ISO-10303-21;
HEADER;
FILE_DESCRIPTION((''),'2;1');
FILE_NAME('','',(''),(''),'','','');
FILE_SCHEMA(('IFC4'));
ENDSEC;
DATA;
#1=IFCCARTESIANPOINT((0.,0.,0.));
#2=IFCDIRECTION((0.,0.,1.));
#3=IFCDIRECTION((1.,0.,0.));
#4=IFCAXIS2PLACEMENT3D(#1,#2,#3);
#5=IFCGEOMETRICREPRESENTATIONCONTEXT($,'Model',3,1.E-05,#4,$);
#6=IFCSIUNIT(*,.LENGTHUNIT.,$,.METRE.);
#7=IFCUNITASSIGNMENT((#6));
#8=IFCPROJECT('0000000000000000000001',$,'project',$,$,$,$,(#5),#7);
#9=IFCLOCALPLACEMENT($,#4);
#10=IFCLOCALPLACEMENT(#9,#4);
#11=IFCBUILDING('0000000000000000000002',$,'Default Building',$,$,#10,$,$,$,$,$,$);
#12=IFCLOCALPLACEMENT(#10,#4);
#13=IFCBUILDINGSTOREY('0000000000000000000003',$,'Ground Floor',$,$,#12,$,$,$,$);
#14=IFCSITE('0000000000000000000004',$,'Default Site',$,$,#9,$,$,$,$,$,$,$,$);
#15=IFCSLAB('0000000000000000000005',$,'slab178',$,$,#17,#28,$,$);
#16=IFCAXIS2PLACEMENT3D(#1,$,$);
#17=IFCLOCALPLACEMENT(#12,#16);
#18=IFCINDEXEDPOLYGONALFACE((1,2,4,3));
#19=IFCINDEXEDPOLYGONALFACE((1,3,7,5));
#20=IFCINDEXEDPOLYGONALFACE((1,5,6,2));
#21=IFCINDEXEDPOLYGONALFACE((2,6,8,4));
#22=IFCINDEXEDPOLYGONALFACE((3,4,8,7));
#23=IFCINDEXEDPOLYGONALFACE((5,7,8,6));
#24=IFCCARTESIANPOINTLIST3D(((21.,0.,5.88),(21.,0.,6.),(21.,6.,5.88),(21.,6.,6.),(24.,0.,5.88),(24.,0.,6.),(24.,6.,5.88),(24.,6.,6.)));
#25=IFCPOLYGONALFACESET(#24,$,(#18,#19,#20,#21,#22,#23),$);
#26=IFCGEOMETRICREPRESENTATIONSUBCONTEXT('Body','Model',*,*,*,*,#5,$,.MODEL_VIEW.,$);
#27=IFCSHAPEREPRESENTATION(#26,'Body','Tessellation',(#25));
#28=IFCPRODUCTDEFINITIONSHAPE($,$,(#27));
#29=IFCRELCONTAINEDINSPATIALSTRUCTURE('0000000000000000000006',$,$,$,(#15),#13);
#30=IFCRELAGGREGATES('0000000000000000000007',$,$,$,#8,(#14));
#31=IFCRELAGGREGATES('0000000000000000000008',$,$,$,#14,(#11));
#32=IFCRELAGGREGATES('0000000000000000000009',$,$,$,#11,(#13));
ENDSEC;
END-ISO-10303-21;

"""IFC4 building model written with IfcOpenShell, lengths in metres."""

from ifc_helpers import new_model, si_unit, frame, origin_with_axes, place, context, subcontext, project, spatial, indexed_curve, outline, extrude, element, save


model = new_model("IFC4")

# Units and contexts
model_context = context("Model", 3, precision=1e-05, world=origin_with_axes())
body_context = subcontext(model_context, "Body", "Model", "MODEL_VIEW")
ifc_project = project(units=[si_unit("LENGTHUNIT", "METRE")], contexts=[model_context])

# Site, building, storey
site_placement = place(None, origin_with_axes())
site = spatial("IfcSite", under=ifc_project, at=site_placement, Name="Default Site")
building_placement = place(site_placement, origin_with_axes())
building = spatial("IfcBuilding", under=site, at=building_placement, Name="Default Building")
storey_placement = place(building_placement, origin_with_axes())
storey = spatial("IfcBuildingStorey", under=building, at=storey_placement, Name="Ground Floor")

# Slab
for number, where, z_axis, x_axis, name in (
    (1, (21.0, 0.0, 5.88), (0.0, 0.0, 1.0), (1.0, 0.0, 0.0), "slab178"),
):
    element("IfcSlab", number, at=place(storey_placement, frame(where, z_axis=z_axis, x_axis=x_axis)), inside=storey, Name=name, context=body_context, shape_type="SweptSolid", body=[
        extrude(outline(indexed_curve([(0.0, 0.0), (0.0, 6.0), (3.0, 6.0), (3.0, 0.0), (0.0, 0.0)], self_intersect=False)), origin_with_axes(), (0.0, 0.0, 1.0), 0.12),
    ])

save(model, "model.ifc")
